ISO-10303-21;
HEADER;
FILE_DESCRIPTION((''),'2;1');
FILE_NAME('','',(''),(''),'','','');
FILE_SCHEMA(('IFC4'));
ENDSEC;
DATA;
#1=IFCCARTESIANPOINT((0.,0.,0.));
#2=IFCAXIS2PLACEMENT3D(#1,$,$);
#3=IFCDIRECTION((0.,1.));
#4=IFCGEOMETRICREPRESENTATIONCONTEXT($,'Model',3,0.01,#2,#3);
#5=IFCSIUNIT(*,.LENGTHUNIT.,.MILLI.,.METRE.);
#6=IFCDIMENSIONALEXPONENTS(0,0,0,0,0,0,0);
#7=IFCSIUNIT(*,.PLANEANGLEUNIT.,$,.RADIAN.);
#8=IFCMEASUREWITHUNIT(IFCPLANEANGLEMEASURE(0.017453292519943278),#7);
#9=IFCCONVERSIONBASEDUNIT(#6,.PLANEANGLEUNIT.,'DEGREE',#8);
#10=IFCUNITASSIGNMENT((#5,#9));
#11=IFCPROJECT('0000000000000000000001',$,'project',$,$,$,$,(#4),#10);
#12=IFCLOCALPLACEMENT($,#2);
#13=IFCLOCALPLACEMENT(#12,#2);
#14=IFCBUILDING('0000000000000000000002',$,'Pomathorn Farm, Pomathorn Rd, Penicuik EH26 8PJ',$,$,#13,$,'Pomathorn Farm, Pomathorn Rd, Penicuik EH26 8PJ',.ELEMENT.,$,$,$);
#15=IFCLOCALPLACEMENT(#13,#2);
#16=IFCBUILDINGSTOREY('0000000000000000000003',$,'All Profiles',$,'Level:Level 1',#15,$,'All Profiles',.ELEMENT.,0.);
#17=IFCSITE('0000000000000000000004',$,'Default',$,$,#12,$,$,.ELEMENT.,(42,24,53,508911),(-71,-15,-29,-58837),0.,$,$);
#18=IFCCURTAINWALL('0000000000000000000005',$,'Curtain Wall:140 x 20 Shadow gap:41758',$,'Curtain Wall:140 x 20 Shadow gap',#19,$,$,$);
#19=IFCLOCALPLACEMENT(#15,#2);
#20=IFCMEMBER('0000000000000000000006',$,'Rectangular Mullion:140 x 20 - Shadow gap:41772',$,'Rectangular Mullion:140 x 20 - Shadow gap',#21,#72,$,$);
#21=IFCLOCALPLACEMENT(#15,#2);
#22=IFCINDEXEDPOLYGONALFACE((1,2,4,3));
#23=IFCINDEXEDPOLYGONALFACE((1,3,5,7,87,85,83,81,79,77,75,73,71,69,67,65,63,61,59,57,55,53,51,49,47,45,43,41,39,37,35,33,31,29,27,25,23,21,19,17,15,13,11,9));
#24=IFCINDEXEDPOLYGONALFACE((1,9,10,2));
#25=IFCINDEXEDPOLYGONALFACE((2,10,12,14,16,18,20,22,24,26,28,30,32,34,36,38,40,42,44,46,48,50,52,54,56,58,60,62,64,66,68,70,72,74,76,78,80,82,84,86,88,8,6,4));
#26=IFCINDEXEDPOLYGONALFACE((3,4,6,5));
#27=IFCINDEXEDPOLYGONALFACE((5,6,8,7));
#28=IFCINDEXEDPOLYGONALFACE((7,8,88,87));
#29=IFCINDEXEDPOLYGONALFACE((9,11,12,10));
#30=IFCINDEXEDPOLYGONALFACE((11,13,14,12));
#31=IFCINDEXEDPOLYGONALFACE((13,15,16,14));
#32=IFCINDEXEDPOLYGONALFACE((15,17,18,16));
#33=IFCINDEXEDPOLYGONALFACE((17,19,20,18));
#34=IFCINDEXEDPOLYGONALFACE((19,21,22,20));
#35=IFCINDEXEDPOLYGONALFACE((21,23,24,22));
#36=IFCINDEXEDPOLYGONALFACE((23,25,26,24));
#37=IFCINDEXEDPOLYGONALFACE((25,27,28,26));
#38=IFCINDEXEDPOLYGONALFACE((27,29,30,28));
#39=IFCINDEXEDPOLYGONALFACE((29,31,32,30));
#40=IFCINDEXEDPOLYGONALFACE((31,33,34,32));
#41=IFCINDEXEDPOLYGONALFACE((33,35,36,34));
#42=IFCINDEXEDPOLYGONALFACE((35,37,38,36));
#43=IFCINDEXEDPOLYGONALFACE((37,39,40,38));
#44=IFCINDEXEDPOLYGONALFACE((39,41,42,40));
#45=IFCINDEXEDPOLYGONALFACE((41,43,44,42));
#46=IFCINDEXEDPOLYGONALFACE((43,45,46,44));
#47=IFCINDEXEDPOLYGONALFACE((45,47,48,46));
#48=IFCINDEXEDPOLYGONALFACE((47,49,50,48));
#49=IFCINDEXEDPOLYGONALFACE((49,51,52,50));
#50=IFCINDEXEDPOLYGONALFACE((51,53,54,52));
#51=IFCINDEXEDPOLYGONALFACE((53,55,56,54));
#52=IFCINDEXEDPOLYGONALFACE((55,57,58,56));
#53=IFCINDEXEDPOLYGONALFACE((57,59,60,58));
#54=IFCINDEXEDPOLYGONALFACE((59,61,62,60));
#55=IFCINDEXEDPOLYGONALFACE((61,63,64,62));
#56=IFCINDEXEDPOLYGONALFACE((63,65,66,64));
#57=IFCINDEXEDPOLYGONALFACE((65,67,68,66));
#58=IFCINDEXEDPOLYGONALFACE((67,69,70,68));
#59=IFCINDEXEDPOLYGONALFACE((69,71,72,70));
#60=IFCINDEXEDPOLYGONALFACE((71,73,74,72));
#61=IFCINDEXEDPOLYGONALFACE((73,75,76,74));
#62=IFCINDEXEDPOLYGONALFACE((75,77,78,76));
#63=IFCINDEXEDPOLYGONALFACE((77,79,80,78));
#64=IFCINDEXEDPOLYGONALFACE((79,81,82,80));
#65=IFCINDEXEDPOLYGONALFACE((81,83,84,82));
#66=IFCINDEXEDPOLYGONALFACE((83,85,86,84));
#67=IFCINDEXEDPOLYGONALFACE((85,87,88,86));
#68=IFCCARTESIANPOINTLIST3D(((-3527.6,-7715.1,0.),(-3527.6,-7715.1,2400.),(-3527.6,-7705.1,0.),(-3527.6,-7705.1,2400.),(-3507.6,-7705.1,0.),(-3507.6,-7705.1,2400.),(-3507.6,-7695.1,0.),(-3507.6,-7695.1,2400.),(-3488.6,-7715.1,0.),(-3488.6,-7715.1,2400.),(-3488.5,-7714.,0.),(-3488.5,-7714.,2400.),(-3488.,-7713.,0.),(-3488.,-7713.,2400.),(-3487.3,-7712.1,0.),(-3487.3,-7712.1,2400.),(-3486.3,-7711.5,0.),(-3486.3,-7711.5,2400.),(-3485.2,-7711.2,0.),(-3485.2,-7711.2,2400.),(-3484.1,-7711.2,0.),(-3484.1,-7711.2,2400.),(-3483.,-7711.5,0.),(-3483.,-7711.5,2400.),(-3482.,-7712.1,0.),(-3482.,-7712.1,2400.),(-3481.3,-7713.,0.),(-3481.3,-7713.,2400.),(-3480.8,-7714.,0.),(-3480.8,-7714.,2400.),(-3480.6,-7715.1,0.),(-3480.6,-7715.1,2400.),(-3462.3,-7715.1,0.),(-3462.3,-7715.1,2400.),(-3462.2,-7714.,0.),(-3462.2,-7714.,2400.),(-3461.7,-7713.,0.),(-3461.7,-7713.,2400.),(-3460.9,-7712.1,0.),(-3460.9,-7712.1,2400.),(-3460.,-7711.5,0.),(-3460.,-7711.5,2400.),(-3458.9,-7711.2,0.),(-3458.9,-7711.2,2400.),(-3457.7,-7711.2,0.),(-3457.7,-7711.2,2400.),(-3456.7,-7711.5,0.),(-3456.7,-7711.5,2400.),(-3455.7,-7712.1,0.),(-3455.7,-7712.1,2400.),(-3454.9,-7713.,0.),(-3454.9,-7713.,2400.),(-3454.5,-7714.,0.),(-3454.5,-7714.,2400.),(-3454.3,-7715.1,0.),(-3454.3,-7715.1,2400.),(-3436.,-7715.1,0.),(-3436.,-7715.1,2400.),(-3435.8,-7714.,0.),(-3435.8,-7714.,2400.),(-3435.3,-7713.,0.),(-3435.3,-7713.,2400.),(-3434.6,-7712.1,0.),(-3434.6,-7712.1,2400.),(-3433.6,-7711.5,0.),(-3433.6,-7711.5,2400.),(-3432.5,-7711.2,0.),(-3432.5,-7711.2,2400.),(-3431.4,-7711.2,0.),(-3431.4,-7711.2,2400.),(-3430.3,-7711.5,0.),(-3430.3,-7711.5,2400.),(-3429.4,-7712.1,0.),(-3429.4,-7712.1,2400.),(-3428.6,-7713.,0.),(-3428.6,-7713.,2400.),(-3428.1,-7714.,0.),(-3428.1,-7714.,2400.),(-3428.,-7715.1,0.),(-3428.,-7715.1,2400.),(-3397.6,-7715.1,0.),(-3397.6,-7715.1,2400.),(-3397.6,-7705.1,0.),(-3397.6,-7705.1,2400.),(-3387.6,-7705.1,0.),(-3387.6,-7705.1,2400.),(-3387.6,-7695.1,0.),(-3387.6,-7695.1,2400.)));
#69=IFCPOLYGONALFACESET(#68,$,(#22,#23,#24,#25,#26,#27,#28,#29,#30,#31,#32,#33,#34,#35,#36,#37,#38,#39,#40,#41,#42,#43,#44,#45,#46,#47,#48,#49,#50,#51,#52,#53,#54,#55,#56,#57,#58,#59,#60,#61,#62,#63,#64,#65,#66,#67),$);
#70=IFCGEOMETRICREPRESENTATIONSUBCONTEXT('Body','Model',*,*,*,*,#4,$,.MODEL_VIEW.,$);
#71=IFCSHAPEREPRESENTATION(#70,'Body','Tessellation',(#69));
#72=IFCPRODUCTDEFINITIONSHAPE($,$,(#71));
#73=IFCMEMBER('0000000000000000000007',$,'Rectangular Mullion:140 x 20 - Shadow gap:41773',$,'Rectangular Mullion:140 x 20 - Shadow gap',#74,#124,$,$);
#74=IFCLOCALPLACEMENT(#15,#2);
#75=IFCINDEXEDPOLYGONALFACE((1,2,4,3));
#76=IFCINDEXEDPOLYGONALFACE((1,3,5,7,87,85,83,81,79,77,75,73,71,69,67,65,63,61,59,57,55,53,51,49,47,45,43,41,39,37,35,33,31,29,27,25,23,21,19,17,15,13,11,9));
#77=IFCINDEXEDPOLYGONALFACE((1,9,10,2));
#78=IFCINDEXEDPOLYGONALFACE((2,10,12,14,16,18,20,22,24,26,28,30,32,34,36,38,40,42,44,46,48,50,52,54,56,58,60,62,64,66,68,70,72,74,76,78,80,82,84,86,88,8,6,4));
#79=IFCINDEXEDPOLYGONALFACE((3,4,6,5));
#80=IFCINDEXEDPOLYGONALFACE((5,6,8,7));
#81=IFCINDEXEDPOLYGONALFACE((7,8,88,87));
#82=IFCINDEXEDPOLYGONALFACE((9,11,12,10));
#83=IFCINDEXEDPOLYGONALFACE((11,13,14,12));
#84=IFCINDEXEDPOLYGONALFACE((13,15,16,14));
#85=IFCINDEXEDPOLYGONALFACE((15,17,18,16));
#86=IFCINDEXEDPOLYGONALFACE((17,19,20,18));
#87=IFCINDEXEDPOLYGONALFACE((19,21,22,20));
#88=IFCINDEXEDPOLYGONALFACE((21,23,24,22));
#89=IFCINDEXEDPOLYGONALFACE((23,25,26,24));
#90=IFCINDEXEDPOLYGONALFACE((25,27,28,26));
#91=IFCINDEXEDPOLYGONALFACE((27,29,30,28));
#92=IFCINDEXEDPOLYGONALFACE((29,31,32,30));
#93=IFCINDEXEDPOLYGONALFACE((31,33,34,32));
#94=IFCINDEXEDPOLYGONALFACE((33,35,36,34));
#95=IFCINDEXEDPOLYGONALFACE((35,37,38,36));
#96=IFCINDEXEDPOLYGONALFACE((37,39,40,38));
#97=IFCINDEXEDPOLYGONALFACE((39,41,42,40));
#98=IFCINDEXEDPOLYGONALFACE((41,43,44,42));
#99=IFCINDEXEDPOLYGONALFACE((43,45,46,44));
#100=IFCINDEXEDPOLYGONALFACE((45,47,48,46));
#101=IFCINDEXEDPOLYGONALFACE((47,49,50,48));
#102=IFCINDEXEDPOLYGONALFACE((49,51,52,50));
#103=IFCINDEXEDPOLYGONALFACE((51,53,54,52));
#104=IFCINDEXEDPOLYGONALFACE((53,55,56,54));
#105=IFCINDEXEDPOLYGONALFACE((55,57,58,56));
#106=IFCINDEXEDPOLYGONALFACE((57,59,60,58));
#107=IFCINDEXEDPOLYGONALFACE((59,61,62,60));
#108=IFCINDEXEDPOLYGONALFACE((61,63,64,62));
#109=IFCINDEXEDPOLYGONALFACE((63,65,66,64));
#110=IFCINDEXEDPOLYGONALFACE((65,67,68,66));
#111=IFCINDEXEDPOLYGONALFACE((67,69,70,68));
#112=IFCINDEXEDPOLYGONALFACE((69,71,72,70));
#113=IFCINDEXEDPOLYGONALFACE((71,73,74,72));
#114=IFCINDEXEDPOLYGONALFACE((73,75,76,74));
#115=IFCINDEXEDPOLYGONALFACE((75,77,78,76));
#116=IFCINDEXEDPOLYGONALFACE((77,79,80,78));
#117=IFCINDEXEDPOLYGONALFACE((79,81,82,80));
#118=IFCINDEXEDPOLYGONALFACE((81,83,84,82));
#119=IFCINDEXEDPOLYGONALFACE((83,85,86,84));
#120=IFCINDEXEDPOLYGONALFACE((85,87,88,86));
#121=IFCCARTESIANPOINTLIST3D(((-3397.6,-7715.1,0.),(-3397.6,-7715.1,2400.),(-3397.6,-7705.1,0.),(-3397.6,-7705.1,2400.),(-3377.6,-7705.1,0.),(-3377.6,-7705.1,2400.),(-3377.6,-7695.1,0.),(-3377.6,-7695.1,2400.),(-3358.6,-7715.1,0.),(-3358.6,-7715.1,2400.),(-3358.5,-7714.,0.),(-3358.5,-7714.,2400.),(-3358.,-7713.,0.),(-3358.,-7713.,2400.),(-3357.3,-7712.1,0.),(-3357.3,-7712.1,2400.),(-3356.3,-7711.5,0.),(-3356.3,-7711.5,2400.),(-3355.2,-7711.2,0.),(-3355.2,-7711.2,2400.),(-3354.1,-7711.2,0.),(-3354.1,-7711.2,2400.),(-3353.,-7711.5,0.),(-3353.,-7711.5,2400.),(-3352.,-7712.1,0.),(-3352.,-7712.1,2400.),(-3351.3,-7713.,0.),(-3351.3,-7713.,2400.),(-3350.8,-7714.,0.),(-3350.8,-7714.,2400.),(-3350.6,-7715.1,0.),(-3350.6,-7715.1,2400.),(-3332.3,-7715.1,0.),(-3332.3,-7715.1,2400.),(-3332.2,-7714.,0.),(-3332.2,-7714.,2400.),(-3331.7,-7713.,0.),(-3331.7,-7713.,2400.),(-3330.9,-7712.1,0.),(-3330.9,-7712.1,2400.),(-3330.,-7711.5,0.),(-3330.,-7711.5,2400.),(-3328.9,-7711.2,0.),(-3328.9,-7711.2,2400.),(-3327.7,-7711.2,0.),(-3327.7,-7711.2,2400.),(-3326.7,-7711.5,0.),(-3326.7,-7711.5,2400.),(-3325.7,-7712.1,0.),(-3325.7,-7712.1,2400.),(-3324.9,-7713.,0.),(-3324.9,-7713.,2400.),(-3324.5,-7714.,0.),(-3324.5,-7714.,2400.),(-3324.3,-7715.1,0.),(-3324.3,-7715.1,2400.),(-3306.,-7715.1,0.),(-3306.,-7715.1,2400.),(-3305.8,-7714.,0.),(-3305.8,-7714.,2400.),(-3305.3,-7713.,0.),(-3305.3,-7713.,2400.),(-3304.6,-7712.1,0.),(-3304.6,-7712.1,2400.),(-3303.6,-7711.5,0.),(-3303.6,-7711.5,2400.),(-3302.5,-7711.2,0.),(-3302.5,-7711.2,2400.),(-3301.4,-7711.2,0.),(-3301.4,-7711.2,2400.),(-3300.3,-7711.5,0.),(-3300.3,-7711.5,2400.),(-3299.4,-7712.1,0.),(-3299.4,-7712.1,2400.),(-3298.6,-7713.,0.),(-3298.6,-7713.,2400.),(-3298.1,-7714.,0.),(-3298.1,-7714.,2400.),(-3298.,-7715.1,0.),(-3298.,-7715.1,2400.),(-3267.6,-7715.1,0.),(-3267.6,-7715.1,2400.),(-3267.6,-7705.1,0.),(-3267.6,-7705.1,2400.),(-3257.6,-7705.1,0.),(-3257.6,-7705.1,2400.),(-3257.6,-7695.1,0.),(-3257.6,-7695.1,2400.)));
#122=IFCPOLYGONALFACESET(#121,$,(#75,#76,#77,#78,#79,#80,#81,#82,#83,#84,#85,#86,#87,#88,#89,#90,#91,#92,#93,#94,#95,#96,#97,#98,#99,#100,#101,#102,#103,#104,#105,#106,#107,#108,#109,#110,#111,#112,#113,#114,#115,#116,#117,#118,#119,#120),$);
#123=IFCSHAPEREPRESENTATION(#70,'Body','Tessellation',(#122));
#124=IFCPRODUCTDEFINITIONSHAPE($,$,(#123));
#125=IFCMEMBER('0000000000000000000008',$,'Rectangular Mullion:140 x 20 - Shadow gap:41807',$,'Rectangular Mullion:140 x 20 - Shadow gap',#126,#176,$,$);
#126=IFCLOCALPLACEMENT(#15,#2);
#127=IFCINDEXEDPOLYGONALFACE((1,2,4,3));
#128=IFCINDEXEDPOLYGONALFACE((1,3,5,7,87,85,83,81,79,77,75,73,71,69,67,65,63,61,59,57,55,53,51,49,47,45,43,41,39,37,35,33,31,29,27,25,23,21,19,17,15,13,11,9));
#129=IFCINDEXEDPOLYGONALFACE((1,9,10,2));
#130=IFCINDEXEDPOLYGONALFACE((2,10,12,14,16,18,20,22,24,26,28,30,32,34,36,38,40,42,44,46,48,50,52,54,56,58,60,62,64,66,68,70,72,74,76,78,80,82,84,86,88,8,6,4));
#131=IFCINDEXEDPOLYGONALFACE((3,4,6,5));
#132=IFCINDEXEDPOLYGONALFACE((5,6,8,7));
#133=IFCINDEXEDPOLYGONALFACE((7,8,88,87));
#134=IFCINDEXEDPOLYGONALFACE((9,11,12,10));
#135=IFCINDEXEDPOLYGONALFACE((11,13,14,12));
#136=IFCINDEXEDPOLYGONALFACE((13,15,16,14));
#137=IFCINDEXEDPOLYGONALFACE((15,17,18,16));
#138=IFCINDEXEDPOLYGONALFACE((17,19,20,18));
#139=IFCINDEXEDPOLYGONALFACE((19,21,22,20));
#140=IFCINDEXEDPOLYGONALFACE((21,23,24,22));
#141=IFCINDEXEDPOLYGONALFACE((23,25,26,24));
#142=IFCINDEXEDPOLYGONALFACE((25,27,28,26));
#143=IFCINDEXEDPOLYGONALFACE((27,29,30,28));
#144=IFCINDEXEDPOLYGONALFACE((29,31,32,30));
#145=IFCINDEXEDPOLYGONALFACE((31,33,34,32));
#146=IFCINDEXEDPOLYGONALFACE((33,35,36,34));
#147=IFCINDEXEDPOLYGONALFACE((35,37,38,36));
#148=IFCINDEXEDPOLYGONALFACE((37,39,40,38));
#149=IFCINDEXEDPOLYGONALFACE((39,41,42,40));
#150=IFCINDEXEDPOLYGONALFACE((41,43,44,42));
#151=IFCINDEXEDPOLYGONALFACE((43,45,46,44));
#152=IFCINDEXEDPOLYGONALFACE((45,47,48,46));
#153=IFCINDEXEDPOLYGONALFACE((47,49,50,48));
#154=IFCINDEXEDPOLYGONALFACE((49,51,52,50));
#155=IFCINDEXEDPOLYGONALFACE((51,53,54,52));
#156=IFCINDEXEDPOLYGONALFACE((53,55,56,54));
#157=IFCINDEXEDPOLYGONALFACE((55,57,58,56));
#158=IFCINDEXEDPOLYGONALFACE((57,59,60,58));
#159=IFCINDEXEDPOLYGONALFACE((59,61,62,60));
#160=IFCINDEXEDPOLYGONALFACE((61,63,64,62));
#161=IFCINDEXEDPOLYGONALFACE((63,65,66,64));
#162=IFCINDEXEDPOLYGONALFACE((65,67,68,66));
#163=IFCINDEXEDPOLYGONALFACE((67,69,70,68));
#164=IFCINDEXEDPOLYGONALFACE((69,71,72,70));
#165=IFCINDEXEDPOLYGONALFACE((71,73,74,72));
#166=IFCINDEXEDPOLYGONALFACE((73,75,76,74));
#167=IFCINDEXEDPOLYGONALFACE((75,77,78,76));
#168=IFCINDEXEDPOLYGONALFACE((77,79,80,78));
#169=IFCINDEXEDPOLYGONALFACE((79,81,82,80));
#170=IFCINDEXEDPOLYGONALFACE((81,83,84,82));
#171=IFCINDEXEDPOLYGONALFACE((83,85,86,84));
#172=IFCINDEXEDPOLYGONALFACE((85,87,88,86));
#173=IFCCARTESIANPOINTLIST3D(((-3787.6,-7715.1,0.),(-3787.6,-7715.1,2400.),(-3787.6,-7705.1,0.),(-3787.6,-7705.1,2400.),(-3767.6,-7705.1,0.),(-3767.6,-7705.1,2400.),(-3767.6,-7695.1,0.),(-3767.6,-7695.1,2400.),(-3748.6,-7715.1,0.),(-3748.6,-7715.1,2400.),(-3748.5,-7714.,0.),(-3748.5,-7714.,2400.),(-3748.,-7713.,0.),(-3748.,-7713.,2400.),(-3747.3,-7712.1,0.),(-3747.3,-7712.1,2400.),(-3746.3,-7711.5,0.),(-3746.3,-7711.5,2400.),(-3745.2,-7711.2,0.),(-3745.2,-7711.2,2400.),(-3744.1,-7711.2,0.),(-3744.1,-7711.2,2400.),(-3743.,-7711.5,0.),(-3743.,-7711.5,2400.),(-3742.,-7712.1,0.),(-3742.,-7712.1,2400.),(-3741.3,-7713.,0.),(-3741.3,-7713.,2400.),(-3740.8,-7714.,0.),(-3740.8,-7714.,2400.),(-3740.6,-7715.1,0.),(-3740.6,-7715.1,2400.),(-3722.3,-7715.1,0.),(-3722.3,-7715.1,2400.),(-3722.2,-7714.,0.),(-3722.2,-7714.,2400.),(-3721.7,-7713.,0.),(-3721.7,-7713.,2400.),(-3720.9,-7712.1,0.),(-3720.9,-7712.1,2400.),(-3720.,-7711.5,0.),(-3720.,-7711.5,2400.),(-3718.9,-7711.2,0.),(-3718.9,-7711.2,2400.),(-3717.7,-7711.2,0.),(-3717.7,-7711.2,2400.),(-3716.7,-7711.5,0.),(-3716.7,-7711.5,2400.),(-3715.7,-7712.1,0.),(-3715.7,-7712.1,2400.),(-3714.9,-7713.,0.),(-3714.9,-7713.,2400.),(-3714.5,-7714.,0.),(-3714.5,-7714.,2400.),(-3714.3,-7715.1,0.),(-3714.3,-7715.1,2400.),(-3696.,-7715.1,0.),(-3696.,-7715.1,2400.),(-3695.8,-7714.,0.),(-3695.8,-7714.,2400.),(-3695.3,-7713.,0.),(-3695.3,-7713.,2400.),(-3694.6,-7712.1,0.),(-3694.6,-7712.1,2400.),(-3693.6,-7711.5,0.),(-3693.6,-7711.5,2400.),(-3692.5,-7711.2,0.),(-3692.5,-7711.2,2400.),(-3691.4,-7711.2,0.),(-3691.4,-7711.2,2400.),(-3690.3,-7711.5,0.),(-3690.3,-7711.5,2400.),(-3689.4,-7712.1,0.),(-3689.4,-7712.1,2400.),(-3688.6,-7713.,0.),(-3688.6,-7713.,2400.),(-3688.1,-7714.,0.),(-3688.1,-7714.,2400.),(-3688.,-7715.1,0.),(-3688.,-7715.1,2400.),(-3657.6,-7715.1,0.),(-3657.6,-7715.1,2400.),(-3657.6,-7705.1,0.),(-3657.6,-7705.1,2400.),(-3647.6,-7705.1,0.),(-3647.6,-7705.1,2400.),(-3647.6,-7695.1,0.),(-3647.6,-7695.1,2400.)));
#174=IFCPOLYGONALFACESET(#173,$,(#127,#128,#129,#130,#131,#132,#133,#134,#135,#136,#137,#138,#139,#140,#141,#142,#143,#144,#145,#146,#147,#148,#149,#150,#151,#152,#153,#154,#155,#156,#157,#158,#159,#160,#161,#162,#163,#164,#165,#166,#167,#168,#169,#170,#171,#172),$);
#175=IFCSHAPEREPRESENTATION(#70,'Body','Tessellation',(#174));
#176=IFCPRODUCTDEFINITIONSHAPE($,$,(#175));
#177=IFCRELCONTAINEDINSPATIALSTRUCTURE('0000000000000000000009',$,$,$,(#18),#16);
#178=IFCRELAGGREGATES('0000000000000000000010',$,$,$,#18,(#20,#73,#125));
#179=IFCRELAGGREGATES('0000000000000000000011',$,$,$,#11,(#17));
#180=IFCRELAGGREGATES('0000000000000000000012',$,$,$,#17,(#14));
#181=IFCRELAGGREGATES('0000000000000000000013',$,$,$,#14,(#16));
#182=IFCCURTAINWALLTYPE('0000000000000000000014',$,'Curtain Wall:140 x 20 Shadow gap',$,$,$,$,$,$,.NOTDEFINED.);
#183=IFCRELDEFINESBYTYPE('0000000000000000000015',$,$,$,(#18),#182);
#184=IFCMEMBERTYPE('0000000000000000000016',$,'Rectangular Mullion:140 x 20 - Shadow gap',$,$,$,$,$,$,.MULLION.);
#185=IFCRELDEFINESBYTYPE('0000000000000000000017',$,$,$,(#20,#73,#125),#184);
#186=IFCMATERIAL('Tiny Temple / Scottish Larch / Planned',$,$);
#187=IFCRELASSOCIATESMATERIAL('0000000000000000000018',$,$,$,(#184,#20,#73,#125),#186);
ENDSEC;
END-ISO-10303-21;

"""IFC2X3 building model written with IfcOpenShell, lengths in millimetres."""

from ifc_helpers import new_model, entity, si_unit, converted_unit, direction, frame, frame_2d, origin, place, context, subcontext, project, spatial, polyline, circle_curve, parameter, trimmed, segment, composite_curve, outline, extrude, source, transform, mapped, material, type_object, type_shapes, element, aggregate, save


model = new_model("IFC2X3")

# Units and contexts
model_context = context("Model", 3, precision=0.01, world=origin(), true_north=direction((0.0, 1.0)))
body_context = subcontext(model_context, "Body", "Model", "MODEL_VIEW")
ifc_project = project(units=[si_unit("LENGTHUNIT", "METRE", prefix="MILLI"), converted_unit("PLANEANGLEUNIT", "DEGREE", entity("IfcPlaneAngleMeasure", 0.017453292519943278), si_unit("PLANEANGLEUNIT", "RADIAN"), dimensions=[0, 0, 0, 0, 0, 0, 0])], contexts=[model_context])

# Site, building, storey
site_placement = place(None, origin())
site = spatial("IfcSite", under=ifc_project, at=site_placement, Name="Default", CompositionType="ELEMENT", RefLatitude=(42, 24, 53, 508911), RefLongitude=(-71, -15, -29, -58837), RefElevation=0.0)
building_placement = place(site_placement, origin())
building = spatial("IfcBuilding", under=site, at=building_placement, Name="Pomathorn Farm, Pomathorn Rd, Penicuik EH26 8PJ", LongName="Pomathorn Farm, Pomathorn Rd, Penicuik EH26 8PJ", CompositionType="ELEMENT")
storey_placement = place(building_placement, origin())
storey = spatial("IfcBuildingStorey", under=building, at=storey_placement, Name="All Profiles", ObjectType="Level:Level 1", LongName="All Profiles", CompositionType="ELEMENT", Elevation=0.0)

# Curtain wall, members
ifc_material = material(Name="Tiny Temple / Scottish Larch / Planned")
curtain_wall_type_1 = type_object("IfcCurtainWallType", Name="Curtain Wall:140 x 20 Shadow gap", PredefinedType="NOTDEFINED")
curtain_wall_1_placement = place(storey_placement, origin())
curtain_wall_1 = element("IfcCurtainWall", 1, at=curtain_wall_1_placement, inside=storey, type_object=curtain_wall_type_1, Name="Curtain Wall:140 x 20 Shadow gap:41758", ObjectType="Curtain Wall:140 x 20 Shadow gap")
member_type_1 = type_object("IfcMemberType", Name="Rectangular Mullion:140 x 20 - Shadow gap", PredefinedType="MULLION", material=ifc_material)
shared_shape_1 = source(origin(), body_context, "Body", "SweptSolid", [
    extrude(outline(composite_curve([segment(polyline([(28.5, -5.7), (58.9, -5.7)]), True, "CONTINUOUS"), segment(polyline([(58.9, -5.7), (58.9, 4.3)]), True, "CONTINUOUS"), segment(polyline([(58.9, 4.3), (68.9, 4.3)]), True, "CONTINUOUS"), segment(polyline([(68.9, 4.3), (68.9, 14.3)]), True, "CONTINUOUS"), segment(polyline([(68.9, 14.3), (-51.1, 14.3)]), True, "CONTINUOUS"), segment(polyline([(-51.1, 14.3), (-51.1, 4.3)]), True, "CONTINUOUS"), segment(polyline([(-51.1, 4.3), (-71.1, 4.3)]), True, "CONTINUOUS"), segment(polyline([(-71.1, 4.3), (-71.1, -5.7)]), True, "CONTINUOUS"), segment(polyline([(-71.1, -5.7), (-32.1, -5.7)]), True, "CONTINUOUS"), segment(trimmed(circle_curve(frame_2d((-28.1, -5.7), x_axis=(1.0, 0.0)), 4.0), [parameter(360.0)], [parameter(180.0)], True, "PARAMETER"), False, "CONTINUOUS"), segment(polyline([(-24.1, -5.7), (-5.8, -5.7)]), True, "CONTINUOUS"), segment(trimmed(circle_curve(frame_2d((-1.8, -5.7), x_axis=(1.0, 0.0)), 4.0), [parameter(360.0)], [parameter(180.0)], True, "PARAMETER"), False, "CONTINUOUS"), segment(polyline([(2.2, -5.7), (20.5, -5.7)]), True, "CONTINUOUS"), segment(trimmed(circle_curve(frame_2d((24.5, -5.7), x_axis=(1.0, 0.0)), 4.0), [parameter(360.0)], [parameter(180.0)], True, "PARAMETER"), False, "CONTINUOUS")], self_intersect=False)), frame((-68.9, -5.7, -2400.0), z_axis=(0.0, 0.0, -1.0), x_axis=(1.0, 0.0, 0.0)), (0.0, 0.0, -1.0), 2400.0),
])
type_shapes(member_type_1, [shared_shape_1])
member_1_placement = place(curtain_wall_1_placement, frame((-3387.6, -7715.1, 0.0), z_axis=(0.0, 0.0, -1.0), x_axis=(1.0, 0.0, 0.0)))
member_1 = element("IfcMember", 2, at=member_1_placement, type_object=member_type_1, material=ifc_material, Name="Rectangular Mullion:140 x 20 - Shadow gap:41772", ObjectType="Rectangular Mullion:140 x 20 - Shadow gap", context=body_context, shape_type="MappedRepresentation", body=[
    mapped(shared_shape_1, transform((0.0, 0.0, 0.0), scale=1.0)),
])
member_2_placement = place(curtain_wall_1_placement, frame((-3257.6, -7715.1, 0.0), z_axis=(0.0, 0.0, -1.0), x_axis=(1.0, 0.0, 0.0)))
member_2 = element("IfcMember", 3, at=member_2_placement, type_object=member_type_1, material=ifc_material, Name="Rectangular Mullion:140 x 20 - Shadow gap:41773", ObjectType="Rectangular Mullion:140 x 20 - Shadow gap", context=body_context, shape_type="MappedRepresentation", body=[
    mapped(shared_shape_1, transform((0.0, 0.0, 0.0), scale=1.0)),
])
member_3_placement = place(curtain_wall_1_placement, frame((-3647.6, -7715.1, 0.0), z_axis=(0.0, 0.0, -1.0), x_axis=(1.0, 0.0, 0.0)))
member_3 = element("IfcMember", 4, at=member_3_placement, type_object=member_type_1, material=ifc_material, Name="Rectangular Mullion:140 x 20 - Shadow gap:41807", ObjectType="Rectangular Mullion:140 x 20 - Shadow gap", context=body_context, shape_type="MappedRepresentation", body=[
    mapped(shared_shape_1, transform((0.0, 0.0, 0.0), scale=1.0)),
])
aggregate(curtain_wall_1, [member_1, member_2, member_3])

save(model, "model.ifc")
